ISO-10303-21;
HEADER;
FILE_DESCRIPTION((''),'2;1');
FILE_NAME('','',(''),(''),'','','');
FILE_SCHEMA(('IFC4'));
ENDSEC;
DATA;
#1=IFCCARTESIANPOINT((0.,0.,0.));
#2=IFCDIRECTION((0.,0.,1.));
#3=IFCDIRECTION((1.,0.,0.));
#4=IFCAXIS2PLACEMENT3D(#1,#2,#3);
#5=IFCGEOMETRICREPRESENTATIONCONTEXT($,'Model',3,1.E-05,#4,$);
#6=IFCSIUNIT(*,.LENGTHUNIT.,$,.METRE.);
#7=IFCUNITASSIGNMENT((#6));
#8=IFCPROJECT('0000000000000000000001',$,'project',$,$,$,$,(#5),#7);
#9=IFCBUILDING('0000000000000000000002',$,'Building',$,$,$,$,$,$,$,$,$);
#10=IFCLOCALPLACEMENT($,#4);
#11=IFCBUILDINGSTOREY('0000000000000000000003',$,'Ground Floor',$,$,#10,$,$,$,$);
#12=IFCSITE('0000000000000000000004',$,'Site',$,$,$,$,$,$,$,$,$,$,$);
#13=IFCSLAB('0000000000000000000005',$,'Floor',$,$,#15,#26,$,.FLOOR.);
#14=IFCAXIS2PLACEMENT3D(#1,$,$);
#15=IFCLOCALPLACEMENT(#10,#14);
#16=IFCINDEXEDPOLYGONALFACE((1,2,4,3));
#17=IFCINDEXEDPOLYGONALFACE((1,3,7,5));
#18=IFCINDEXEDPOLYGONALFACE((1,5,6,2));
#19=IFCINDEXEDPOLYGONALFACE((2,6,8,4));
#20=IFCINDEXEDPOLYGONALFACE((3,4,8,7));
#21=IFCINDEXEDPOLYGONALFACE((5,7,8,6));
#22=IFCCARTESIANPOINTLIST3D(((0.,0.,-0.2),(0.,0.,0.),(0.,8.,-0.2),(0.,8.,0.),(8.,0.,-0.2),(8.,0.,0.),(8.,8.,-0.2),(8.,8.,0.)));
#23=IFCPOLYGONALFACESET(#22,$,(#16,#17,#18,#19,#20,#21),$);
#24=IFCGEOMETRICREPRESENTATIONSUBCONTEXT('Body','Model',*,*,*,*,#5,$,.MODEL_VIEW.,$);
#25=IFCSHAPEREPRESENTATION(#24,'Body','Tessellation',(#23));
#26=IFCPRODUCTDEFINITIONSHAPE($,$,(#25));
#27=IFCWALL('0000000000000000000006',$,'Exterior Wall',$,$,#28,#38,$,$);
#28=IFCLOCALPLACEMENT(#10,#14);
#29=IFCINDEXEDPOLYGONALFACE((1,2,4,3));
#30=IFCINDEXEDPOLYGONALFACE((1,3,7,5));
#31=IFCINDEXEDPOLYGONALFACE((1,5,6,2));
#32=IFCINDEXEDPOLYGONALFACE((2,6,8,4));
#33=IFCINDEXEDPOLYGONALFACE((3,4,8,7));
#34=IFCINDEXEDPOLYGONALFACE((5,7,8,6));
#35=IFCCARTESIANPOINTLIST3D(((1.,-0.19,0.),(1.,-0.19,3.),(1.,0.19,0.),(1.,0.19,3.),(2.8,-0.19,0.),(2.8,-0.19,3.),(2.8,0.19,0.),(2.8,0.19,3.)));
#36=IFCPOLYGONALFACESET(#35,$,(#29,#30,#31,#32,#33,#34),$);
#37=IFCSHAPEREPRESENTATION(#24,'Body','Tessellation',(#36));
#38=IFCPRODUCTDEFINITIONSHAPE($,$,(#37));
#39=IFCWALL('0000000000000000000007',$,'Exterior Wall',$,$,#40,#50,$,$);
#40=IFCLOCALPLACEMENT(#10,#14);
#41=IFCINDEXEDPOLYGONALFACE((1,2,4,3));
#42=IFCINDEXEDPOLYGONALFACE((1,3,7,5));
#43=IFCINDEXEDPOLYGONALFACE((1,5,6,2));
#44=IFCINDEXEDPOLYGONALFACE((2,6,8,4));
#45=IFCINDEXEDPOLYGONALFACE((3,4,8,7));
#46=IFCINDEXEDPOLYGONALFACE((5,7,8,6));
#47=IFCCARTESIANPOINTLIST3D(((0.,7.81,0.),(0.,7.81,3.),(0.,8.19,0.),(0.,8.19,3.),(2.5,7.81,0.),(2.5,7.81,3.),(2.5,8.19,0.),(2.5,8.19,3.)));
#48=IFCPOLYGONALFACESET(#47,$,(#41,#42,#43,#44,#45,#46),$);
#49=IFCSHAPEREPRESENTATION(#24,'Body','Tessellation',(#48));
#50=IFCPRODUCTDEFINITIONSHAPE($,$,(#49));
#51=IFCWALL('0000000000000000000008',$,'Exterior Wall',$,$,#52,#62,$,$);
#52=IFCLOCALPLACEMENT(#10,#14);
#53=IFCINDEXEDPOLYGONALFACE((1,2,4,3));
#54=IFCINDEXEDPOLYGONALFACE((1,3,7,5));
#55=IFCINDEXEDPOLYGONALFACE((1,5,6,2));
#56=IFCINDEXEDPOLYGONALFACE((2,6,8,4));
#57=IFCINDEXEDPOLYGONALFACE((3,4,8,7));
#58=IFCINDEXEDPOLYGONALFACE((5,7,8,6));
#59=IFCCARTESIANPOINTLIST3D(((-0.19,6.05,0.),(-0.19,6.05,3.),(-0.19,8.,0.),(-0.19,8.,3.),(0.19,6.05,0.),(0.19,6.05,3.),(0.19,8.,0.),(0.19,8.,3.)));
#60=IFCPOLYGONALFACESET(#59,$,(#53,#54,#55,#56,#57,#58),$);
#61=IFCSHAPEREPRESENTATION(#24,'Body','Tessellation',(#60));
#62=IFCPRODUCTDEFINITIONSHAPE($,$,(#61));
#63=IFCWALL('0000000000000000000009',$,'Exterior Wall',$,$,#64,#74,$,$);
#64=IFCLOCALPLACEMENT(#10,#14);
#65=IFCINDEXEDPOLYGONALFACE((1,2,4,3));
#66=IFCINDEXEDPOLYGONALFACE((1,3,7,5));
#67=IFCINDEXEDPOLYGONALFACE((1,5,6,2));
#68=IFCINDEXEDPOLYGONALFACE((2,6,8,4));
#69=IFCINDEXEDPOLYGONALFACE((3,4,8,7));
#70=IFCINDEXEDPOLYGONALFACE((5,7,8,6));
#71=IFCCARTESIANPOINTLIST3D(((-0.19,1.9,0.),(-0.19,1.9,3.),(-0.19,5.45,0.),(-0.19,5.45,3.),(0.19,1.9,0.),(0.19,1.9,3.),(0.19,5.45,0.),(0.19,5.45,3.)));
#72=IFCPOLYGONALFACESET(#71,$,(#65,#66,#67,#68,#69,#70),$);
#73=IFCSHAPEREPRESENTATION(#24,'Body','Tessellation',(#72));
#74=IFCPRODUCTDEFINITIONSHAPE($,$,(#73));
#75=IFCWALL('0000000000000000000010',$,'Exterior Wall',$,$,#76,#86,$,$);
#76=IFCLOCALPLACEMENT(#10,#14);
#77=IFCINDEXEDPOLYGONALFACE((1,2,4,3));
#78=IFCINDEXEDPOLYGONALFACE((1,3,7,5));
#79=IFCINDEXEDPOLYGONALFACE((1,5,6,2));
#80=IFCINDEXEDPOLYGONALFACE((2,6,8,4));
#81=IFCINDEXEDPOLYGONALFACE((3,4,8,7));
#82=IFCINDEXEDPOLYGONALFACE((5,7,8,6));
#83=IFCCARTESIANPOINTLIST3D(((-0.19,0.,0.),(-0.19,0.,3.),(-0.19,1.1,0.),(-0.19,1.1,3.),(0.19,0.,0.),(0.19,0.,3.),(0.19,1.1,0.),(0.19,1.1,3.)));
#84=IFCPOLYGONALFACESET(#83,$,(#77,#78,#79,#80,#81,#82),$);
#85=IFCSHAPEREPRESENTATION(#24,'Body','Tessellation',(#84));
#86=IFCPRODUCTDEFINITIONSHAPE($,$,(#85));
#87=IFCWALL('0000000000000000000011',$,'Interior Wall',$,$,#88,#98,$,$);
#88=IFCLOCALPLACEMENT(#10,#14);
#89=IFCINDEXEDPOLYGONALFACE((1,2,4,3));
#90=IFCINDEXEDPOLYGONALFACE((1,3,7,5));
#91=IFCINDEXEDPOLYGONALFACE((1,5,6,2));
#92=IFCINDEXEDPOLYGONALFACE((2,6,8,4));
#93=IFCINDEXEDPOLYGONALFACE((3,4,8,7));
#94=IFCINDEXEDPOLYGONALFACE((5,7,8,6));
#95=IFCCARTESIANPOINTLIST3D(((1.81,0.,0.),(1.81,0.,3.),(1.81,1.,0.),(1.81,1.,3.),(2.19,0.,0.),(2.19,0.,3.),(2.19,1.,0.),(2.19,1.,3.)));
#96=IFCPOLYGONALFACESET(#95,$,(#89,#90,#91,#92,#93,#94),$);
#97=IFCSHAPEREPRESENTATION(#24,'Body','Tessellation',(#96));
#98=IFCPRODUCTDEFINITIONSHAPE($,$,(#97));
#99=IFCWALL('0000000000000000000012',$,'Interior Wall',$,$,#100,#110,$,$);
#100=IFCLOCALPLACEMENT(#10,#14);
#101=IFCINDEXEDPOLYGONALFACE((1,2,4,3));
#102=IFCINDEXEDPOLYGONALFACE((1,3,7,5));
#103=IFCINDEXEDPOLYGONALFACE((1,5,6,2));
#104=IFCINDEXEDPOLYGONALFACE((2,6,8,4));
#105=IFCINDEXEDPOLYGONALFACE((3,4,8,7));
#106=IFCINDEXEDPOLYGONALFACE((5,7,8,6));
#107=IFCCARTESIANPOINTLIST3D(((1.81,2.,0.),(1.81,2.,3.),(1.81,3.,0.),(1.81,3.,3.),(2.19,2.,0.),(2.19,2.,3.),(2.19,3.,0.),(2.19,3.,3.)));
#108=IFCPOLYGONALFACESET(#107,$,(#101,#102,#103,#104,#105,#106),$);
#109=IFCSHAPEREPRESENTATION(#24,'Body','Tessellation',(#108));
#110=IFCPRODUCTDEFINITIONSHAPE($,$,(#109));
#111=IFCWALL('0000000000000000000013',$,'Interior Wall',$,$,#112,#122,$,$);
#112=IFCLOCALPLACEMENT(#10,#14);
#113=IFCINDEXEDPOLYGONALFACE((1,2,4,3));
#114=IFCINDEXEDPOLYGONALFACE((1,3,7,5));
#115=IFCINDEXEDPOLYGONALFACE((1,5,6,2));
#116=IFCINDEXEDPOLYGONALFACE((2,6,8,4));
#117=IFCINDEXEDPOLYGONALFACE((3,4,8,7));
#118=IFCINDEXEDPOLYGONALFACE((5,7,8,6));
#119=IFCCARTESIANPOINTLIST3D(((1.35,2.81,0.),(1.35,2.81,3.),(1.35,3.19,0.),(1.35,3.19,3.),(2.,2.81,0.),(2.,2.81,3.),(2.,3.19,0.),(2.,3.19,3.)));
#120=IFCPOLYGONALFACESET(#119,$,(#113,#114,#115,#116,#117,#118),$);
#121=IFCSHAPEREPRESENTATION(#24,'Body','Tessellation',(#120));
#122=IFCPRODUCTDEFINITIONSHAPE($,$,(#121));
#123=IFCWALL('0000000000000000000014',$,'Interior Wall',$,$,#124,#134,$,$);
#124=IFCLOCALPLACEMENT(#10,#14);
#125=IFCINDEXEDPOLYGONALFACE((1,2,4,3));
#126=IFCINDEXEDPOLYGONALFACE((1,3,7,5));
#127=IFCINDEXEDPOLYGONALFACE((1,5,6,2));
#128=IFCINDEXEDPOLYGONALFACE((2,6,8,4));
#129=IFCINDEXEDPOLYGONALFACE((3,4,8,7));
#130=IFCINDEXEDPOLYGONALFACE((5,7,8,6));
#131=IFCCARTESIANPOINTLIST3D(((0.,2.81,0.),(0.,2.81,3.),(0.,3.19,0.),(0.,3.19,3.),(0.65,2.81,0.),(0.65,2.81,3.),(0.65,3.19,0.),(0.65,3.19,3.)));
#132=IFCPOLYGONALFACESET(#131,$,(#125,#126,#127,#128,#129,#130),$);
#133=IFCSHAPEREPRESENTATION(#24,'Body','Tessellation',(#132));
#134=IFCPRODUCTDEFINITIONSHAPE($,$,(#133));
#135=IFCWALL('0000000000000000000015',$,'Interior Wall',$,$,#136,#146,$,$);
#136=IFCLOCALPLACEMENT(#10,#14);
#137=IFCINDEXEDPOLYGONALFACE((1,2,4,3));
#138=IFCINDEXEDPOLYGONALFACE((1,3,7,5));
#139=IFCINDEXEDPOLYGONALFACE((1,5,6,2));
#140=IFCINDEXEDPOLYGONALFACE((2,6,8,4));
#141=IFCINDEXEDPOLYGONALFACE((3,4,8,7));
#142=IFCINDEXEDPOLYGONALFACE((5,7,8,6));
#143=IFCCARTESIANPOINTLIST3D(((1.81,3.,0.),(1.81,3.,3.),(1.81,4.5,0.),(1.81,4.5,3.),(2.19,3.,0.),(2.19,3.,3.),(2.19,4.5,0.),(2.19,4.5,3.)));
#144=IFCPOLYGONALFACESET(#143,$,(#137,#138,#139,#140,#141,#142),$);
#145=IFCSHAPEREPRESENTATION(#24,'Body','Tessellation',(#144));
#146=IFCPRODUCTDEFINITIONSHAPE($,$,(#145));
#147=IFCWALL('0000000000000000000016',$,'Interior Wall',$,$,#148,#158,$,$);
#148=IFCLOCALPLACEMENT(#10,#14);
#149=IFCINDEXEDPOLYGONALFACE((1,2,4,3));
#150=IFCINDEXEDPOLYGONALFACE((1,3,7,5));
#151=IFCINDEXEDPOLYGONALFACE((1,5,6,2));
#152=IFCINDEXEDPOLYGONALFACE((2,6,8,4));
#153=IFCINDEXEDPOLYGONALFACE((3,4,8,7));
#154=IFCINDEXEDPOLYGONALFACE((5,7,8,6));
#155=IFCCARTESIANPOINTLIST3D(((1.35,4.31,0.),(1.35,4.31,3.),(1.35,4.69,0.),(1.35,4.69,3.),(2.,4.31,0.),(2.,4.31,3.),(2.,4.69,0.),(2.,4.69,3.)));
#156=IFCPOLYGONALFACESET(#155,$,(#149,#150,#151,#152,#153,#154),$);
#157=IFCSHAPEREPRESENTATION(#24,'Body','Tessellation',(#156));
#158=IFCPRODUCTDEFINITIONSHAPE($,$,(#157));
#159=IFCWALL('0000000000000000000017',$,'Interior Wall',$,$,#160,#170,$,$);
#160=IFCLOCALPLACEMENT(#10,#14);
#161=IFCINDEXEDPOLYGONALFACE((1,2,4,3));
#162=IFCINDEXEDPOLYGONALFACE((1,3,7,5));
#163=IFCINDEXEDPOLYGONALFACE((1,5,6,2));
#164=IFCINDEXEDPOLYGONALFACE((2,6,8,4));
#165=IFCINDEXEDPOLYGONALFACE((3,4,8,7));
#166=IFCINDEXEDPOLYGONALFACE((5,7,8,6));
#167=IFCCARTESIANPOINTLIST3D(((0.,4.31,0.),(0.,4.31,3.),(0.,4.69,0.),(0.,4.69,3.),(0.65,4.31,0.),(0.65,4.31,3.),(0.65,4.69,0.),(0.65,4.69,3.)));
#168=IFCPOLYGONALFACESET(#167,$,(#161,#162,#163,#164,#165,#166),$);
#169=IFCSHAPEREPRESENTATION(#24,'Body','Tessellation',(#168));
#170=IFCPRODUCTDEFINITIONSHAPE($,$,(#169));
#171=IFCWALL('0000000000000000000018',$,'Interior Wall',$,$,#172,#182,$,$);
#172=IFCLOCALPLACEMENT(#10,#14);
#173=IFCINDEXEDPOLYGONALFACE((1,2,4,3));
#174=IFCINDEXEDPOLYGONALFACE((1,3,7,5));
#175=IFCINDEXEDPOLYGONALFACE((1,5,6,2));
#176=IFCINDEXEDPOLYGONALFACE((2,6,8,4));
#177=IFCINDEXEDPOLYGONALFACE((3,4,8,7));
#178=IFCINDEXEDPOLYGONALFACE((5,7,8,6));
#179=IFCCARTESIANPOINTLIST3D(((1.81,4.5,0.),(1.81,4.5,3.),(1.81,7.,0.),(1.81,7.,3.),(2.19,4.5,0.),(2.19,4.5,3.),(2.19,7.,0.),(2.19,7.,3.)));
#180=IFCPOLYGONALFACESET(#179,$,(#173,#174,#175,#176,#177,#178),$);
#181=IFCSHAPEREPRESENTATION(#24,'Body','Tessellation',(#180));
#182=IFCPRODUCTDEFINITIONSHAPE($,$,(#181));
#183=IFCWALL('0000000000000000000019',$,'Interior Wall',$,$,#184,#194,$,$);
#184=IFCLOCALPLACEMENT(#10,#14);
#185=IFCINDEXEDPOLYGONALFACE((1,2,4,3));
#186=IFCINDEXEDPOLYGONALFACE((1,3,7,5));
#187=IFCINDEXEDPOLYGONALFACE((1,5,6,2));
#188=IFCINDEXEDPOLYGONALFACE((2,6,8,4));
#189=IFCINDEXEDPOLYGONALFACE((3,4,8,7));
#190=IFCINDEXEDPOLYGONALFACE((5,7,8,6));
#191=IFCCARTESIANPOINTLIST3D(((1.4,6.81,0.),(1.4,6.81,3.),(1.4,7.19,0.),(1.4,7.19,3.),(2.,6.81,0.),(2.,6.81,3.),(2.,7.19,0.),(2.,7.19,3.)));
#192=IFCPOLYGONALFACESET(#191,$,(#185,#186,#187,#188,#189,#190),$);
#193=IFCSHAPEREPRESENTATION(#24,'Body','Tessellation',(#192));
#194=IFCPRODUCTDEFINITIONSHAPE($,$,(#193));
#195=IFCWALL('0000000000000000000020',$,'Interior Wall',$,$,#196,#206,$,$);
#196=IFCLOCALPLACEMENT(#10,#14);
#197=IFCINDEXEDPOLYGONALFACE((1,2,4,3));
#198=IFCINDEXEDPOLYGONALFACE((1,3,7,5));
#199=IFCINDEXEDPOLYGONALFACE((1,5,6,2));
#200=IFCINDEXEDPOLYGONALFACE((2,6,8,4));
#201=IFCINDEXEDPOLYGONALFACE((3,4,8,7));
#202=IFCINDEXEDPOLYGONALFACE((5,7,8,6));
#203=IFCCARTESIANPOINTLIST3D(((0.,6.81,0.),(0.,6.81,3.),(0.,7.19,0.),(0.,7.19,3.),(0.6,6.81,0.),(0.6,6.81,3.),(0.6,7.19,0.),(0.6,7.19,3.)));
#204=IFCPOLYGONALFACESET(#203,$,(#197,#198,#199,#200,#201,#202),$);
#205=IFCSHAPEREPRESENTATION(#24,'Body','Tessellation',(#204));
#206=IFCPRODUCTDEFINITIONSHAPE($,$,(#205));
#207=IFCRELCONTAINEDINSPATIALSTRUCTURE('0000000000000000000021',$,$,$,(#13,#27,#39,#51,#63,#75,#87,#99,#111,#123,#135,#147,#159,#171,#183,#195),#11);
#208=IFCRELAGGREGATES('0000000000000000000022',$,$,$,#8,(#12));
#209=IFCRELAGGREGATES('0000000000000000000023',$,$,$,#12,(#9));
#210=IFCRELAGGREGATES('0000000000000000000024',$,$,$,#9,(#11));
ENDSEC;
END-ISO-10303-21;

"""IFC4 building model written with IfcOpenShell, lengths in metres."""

from ifc_helpers import new_model, si_unit, frame, origin_with_axes, place, context, subcontext, project, spatial, indexed_curve, outline, extrude, element, save


model = new_model("IFC4")

# Units and contexts
model_context = context("Model", 3, precision=1e-05, world=origin_with_axes())
body_context = subcontext(model_context, "Body", "Model", "MODEL_VIEW")
ifc_project = project(units=[si_unit("LENGTHUNIT", "METRE")], contexts=[model_context])

# Site, building, storey
site = spatial("IfcSite", under=ifc_project, Name="Site")
building = spatial("IfcBuilding", under=site, Name="Building")
storey_placement = place(None, origin_with_axes())
storey = spatial("IfcBuildingStorey", under=building, at=storey_placement, Name="Ground Floor")

# Slab
slab_placement = place(storey_placement, frame((0.0, 0.0, -0.2), z_axis=(0.0, 0.0, 1.0), x_axis=(1.0, 0.0, 0.0)))
element("IfcSlab", 1, at=slab_placement, inside=storey, Name="Floor", PredefinedType="FLOOR", context=body_context, shape_type="SweptSolid", body=[
    extrude(outline(indexed_curve([(0.0, 0.0), (8.0, 0.0), (8.0, 8.0), (0.0, 8.0)])), None, (0.0, 0.0, 1.0), 0.2),
])

# Walls
wall_1_placement = place(storey_placement, frame((1.0, 0.0, 0.0), z_axis=(0.0, 0.0, 1.0), x_axis=(1.0, 0.0, 0.0)))
element("IfcWall", 2, at=wall_1_placement, inside=storey, Name="Exterior Wall", context=body_context, shape_type="SweptSolid", body=[
    extrude(outline(indexed_curve([(0.0, 0.0), (0.0, 0.38), (1.8, 0.38), (1.8, 0.0), (0.0, 0.0)], self_intersect=False)), frame((0.0, -0.19, 0.0), z_axis=(0.0, 0.0, 1.0), x_axis=(1.0, 0.0, 0.0)), (0.0, 0.0, 1.0), 3.0),
])
wall_2_placement = place(storey_placement, frame((2.5, 8.0, 0.0), z_axis=(0.0, 0.0, 1.0), x_axis=(-1.0, 0.0, 0.0)))
element("IfcWall", 3, at=wall_2_placement, inside=storey, Name="Exterior Wall", context=body_context, shape_type="SweptSolid", body=[
    extrude(outline(indexed_curve([(0.0, 0.0), (0.0, 0.38), (2.5, 0.38), (2.5, 0.0), (0.0, 0.0)], self_intersect=False)), frame((0.0, -0.19, 0.0), z_axis=(0.0, 0.0, 1.0), x_axis=(1.0, 0.0, 0.0)), (0.0, 0.0, 1.0), 3.0),
])
wall_3_placement = place(storey_placement, frame((0.0, 8.0, 0.0), z_axis=(0.0, 0.0, 1.0), x_axis=(0.0, -1.0, 0.0)))
element("IfcWall", 4, at=wall_3_placement, inside=storey, Name="Exterior Wall", context=body_context, shape_type="SweptSolid", body=[
    extrude(outline(indexed_curve([(0.0, 0.0), (0.0, 0.38), (1.95, 0.38), (1.95, 0.0), (0.0, 0.0)], self_intersect=False)), frame((0.0, -0.19, 0.0), z_axis=(0.0, 0.0, 1.0), x_axis=(1.0, 0.0, 0.0)), (0.0, 0.0, 1.0), 3.0),
])
wall_4_placement = place(storey_placement, frame((0.0, 5.45, 0.0), z_axis=(0.0, 0.0, 1.0), x_axis=(0.0, -1.0, 0.0)))
element("IfcWall", 5, at=wall_4_placement, inside=storey, Name="Exterior Wall", context=body_context, shape_type="SweptSolid", body=[
    extrude(outline(indexed_curve([(0.0, 0.0), (0.0, 0.38), (3.55, 0.38), (3.55, 0.0), (0.0, 0.0)], self_intersect=False)), frame((0.0, -0.19, 0.0), z_axis=(0.0, 0.0, 1.0), x_axis=(1.0, 0.0, 0.0)), (0.0, 0.0, 1.0), 3.0),
])
wall_5_placement = place(storey_placement, frame((0.0, 1.1, 0.0), z_axis=(0.0, 0.0, 1.0), x_axis=(0.0, -1.0, 0.0)))
element("IfcWall", 6, at=wall_5_placement, inside=storey, Name="Exterior Wall", context=body_context, shape_type="SweptSolid", body=[
    extrude(outline(indexed_curve([(0.0, 0.0), (0.0, 0.38), (1.1, 0.38), (1.1, 0.0), (0.0, 0.0)], self_intersect=False)), frame((0.0, -0.19, 0.0), z_axis=(0.0, 0.0, 1.0), x_axis=(1.0, 0.0, 0.0)), (0.0, 0.0, 1.0), 3.0),
])
for number, where, z_axis, x_axis, name in (
    (7, (2.0, 0.0, 0.0), (0.0, 0.0, 1.0), (0.0, 1.0, 0.0), "Interior Wall"),
    (8, (2.0, 2.0, 0.0), (0.0, 0.0, 1.0), (0.0, 1.0, 0.0), "Interior Wall"),
):
    element("IfcWall", number, at=place(storey_placement, frame(where, z_axis=z_axis, x_axis=x_axis)), inside=storey, Name=name, context=body_context, shape_type="SweptSolid", body=[
        extrude(outline(indexed_curve([(0.0, 0.0), (0.0, 0.38), (1.0, 0.38), (1.0, 0.0), (0.0, 0.0)], self_intersect=False)), frame((0.0, -0.19, 0.0), z_axis=(0.0, 0.0, 1.0), x_axis=(1.0, 0.0, 0.0)), (0.0, 0.0, 1.0), 3.0),
    ])
for number, where, z_axis, x_axis, name in (
    (9, (2.0, 3.0, 0.0), (0.0, 0.0, 1.0), (-1.0, 0.0, 0.0), "Interior Wall"),
    (10, (0.65, 3.0, 0.0), (0.0, 0.0, 1.0), (-1.0, 0.0, 0.0), "Interior Wall"),
):
    element("IfcWall", number, at=place(storey_placement, frame(where, z_axis=z_axis, x_axis=x_axis)), inside=storey, Name=name, context=body_context, shape_type="SweptSolid", body=[
        extrude(outline(indexed_curve([(0.0, 0.0), (0.0, 0.38), (0.65, 0.38), (0.65, 0.0), (0.0, 0.0)], self_intersect=False)), frame((0.0, -0.19, 0.0), z_axis=(0.0, 0.0, 1.0), x_axis=(1.0, 0.0, 0.0)), (0.0, 0.0, 1.0), 3.0),
    ])
wall_6_placement = place(storey_placement, frame((2.0, 4.5, 0.0), z_axis=(0.0, 0.0, 1.0), x_axis=(0.0, -1.0, 0.0)))
element("IfcWall", 11, at=wall_6_placement, inside=storey, Name="Interior Wall", context=body_context, shape_type="SweptSolid", body=[
    extrude(outline(indexed_curve([(0.0, 0.0), (0.0, 0.38), (1.5, 0.38), (1.5, 0.0), (0.0, 0.0)], self_intersect=False)), frame((0.0, -0.19, 0.0), z_axis=(0.0, 0.0, 1.0), x_axis=(1.0, 0.0, 0.0)), (0.0, 0.0, 1.0), 3.0),
])
for number, where, z_axis, x_axis, name in (
    (12, (2.0, 4.5, 0.0), (0.0, 0.0, 1.0), (-1.0, 0.0, 0.0), "Interior Wall"),
    (13, (0.65, 4.5, 0.0), (0.0, 0.0, 1.0), (-1.0, 0.0, 0.0), "Interior Wall"),
):
    element("IfcWall", number, at=place(storey_placement, frame(where, z_axis=z_axis, x_axis=x_axis)), inside=storey, Name=name, context=body_context, shape_type="SweptSolid", body=[
        extrude(outline(indexed_curve([(0.0, 0.0), (0.0, 0.38), (0.65, 0.38), (0.65, 0.0), (0.0, 0.0)], self_intersect=False)), frame((0.0, -0.19, 0.0), z_axis=(0.0, 0.0, 1.0), x_axis=(1.0, 0.0, 0.0)), (0.0, 0.0, 1.0), 3.0),
    ])
wall_7_placement = place(storey_placement, frame((2.0, 4.5, 0.0), z_axis=(0.0, 0.0, 1.0), x_axis=(0.0, 1.0, 0.0)))
element("IfcWall", 14, at=wall_7_placement, inside=storey, Name="Interior Wall", context=body_context, shape_type="SweptSolid", body=[
    extrude(outline(indexed_curve([(0.0, 0.0), (0.0, 0.38), (2.5, 0.38), (2.5, 0.0), (0.0, 0.0)], self_intersect=False)), frame((0.0, -0.19, 0.0), z_axis=(0.0, 0.0, 1.0), x_axis=(1.0, 0.0, 0.0)), (0.0, 0.0, 1.0), 3.0),
])
for number, where, z_axis, x_axis, name in (
    (15, (2.0, 7.0, 0.0), (0.0, 0.0, 1.0), (-1.0, 0.0, 0.0), "Interior Wall"),
    (16, (0.6, 7.0, 0.0), (0.0, 0.0, 1.0), (-1.0, 0.0, 0.0), "Interior Wall"),
):
    element("IfcWall", number, at=place(storey_placement, frame(where, z_axis=z_axis, x_axis=x_axis)), inside=storey, Name=name, context=body_context, shape_type="SweptSolid", body=[
        extrude(outline(indexed_curve([(0.0, 0.0), (0.0, 0.38), (0.6, 0.38), (0.6, 0.0), (0.0, 0.0)], self_intersect=False)), frame((0.0, -0.19, 0.0), z_axis=(0.0, 0.0, 1.0), x_axis=(1.0, 0.0, 0.0)), (0.0, 0.0, 1.0), 3.0),
    ])

save(model, "model.ifc")
